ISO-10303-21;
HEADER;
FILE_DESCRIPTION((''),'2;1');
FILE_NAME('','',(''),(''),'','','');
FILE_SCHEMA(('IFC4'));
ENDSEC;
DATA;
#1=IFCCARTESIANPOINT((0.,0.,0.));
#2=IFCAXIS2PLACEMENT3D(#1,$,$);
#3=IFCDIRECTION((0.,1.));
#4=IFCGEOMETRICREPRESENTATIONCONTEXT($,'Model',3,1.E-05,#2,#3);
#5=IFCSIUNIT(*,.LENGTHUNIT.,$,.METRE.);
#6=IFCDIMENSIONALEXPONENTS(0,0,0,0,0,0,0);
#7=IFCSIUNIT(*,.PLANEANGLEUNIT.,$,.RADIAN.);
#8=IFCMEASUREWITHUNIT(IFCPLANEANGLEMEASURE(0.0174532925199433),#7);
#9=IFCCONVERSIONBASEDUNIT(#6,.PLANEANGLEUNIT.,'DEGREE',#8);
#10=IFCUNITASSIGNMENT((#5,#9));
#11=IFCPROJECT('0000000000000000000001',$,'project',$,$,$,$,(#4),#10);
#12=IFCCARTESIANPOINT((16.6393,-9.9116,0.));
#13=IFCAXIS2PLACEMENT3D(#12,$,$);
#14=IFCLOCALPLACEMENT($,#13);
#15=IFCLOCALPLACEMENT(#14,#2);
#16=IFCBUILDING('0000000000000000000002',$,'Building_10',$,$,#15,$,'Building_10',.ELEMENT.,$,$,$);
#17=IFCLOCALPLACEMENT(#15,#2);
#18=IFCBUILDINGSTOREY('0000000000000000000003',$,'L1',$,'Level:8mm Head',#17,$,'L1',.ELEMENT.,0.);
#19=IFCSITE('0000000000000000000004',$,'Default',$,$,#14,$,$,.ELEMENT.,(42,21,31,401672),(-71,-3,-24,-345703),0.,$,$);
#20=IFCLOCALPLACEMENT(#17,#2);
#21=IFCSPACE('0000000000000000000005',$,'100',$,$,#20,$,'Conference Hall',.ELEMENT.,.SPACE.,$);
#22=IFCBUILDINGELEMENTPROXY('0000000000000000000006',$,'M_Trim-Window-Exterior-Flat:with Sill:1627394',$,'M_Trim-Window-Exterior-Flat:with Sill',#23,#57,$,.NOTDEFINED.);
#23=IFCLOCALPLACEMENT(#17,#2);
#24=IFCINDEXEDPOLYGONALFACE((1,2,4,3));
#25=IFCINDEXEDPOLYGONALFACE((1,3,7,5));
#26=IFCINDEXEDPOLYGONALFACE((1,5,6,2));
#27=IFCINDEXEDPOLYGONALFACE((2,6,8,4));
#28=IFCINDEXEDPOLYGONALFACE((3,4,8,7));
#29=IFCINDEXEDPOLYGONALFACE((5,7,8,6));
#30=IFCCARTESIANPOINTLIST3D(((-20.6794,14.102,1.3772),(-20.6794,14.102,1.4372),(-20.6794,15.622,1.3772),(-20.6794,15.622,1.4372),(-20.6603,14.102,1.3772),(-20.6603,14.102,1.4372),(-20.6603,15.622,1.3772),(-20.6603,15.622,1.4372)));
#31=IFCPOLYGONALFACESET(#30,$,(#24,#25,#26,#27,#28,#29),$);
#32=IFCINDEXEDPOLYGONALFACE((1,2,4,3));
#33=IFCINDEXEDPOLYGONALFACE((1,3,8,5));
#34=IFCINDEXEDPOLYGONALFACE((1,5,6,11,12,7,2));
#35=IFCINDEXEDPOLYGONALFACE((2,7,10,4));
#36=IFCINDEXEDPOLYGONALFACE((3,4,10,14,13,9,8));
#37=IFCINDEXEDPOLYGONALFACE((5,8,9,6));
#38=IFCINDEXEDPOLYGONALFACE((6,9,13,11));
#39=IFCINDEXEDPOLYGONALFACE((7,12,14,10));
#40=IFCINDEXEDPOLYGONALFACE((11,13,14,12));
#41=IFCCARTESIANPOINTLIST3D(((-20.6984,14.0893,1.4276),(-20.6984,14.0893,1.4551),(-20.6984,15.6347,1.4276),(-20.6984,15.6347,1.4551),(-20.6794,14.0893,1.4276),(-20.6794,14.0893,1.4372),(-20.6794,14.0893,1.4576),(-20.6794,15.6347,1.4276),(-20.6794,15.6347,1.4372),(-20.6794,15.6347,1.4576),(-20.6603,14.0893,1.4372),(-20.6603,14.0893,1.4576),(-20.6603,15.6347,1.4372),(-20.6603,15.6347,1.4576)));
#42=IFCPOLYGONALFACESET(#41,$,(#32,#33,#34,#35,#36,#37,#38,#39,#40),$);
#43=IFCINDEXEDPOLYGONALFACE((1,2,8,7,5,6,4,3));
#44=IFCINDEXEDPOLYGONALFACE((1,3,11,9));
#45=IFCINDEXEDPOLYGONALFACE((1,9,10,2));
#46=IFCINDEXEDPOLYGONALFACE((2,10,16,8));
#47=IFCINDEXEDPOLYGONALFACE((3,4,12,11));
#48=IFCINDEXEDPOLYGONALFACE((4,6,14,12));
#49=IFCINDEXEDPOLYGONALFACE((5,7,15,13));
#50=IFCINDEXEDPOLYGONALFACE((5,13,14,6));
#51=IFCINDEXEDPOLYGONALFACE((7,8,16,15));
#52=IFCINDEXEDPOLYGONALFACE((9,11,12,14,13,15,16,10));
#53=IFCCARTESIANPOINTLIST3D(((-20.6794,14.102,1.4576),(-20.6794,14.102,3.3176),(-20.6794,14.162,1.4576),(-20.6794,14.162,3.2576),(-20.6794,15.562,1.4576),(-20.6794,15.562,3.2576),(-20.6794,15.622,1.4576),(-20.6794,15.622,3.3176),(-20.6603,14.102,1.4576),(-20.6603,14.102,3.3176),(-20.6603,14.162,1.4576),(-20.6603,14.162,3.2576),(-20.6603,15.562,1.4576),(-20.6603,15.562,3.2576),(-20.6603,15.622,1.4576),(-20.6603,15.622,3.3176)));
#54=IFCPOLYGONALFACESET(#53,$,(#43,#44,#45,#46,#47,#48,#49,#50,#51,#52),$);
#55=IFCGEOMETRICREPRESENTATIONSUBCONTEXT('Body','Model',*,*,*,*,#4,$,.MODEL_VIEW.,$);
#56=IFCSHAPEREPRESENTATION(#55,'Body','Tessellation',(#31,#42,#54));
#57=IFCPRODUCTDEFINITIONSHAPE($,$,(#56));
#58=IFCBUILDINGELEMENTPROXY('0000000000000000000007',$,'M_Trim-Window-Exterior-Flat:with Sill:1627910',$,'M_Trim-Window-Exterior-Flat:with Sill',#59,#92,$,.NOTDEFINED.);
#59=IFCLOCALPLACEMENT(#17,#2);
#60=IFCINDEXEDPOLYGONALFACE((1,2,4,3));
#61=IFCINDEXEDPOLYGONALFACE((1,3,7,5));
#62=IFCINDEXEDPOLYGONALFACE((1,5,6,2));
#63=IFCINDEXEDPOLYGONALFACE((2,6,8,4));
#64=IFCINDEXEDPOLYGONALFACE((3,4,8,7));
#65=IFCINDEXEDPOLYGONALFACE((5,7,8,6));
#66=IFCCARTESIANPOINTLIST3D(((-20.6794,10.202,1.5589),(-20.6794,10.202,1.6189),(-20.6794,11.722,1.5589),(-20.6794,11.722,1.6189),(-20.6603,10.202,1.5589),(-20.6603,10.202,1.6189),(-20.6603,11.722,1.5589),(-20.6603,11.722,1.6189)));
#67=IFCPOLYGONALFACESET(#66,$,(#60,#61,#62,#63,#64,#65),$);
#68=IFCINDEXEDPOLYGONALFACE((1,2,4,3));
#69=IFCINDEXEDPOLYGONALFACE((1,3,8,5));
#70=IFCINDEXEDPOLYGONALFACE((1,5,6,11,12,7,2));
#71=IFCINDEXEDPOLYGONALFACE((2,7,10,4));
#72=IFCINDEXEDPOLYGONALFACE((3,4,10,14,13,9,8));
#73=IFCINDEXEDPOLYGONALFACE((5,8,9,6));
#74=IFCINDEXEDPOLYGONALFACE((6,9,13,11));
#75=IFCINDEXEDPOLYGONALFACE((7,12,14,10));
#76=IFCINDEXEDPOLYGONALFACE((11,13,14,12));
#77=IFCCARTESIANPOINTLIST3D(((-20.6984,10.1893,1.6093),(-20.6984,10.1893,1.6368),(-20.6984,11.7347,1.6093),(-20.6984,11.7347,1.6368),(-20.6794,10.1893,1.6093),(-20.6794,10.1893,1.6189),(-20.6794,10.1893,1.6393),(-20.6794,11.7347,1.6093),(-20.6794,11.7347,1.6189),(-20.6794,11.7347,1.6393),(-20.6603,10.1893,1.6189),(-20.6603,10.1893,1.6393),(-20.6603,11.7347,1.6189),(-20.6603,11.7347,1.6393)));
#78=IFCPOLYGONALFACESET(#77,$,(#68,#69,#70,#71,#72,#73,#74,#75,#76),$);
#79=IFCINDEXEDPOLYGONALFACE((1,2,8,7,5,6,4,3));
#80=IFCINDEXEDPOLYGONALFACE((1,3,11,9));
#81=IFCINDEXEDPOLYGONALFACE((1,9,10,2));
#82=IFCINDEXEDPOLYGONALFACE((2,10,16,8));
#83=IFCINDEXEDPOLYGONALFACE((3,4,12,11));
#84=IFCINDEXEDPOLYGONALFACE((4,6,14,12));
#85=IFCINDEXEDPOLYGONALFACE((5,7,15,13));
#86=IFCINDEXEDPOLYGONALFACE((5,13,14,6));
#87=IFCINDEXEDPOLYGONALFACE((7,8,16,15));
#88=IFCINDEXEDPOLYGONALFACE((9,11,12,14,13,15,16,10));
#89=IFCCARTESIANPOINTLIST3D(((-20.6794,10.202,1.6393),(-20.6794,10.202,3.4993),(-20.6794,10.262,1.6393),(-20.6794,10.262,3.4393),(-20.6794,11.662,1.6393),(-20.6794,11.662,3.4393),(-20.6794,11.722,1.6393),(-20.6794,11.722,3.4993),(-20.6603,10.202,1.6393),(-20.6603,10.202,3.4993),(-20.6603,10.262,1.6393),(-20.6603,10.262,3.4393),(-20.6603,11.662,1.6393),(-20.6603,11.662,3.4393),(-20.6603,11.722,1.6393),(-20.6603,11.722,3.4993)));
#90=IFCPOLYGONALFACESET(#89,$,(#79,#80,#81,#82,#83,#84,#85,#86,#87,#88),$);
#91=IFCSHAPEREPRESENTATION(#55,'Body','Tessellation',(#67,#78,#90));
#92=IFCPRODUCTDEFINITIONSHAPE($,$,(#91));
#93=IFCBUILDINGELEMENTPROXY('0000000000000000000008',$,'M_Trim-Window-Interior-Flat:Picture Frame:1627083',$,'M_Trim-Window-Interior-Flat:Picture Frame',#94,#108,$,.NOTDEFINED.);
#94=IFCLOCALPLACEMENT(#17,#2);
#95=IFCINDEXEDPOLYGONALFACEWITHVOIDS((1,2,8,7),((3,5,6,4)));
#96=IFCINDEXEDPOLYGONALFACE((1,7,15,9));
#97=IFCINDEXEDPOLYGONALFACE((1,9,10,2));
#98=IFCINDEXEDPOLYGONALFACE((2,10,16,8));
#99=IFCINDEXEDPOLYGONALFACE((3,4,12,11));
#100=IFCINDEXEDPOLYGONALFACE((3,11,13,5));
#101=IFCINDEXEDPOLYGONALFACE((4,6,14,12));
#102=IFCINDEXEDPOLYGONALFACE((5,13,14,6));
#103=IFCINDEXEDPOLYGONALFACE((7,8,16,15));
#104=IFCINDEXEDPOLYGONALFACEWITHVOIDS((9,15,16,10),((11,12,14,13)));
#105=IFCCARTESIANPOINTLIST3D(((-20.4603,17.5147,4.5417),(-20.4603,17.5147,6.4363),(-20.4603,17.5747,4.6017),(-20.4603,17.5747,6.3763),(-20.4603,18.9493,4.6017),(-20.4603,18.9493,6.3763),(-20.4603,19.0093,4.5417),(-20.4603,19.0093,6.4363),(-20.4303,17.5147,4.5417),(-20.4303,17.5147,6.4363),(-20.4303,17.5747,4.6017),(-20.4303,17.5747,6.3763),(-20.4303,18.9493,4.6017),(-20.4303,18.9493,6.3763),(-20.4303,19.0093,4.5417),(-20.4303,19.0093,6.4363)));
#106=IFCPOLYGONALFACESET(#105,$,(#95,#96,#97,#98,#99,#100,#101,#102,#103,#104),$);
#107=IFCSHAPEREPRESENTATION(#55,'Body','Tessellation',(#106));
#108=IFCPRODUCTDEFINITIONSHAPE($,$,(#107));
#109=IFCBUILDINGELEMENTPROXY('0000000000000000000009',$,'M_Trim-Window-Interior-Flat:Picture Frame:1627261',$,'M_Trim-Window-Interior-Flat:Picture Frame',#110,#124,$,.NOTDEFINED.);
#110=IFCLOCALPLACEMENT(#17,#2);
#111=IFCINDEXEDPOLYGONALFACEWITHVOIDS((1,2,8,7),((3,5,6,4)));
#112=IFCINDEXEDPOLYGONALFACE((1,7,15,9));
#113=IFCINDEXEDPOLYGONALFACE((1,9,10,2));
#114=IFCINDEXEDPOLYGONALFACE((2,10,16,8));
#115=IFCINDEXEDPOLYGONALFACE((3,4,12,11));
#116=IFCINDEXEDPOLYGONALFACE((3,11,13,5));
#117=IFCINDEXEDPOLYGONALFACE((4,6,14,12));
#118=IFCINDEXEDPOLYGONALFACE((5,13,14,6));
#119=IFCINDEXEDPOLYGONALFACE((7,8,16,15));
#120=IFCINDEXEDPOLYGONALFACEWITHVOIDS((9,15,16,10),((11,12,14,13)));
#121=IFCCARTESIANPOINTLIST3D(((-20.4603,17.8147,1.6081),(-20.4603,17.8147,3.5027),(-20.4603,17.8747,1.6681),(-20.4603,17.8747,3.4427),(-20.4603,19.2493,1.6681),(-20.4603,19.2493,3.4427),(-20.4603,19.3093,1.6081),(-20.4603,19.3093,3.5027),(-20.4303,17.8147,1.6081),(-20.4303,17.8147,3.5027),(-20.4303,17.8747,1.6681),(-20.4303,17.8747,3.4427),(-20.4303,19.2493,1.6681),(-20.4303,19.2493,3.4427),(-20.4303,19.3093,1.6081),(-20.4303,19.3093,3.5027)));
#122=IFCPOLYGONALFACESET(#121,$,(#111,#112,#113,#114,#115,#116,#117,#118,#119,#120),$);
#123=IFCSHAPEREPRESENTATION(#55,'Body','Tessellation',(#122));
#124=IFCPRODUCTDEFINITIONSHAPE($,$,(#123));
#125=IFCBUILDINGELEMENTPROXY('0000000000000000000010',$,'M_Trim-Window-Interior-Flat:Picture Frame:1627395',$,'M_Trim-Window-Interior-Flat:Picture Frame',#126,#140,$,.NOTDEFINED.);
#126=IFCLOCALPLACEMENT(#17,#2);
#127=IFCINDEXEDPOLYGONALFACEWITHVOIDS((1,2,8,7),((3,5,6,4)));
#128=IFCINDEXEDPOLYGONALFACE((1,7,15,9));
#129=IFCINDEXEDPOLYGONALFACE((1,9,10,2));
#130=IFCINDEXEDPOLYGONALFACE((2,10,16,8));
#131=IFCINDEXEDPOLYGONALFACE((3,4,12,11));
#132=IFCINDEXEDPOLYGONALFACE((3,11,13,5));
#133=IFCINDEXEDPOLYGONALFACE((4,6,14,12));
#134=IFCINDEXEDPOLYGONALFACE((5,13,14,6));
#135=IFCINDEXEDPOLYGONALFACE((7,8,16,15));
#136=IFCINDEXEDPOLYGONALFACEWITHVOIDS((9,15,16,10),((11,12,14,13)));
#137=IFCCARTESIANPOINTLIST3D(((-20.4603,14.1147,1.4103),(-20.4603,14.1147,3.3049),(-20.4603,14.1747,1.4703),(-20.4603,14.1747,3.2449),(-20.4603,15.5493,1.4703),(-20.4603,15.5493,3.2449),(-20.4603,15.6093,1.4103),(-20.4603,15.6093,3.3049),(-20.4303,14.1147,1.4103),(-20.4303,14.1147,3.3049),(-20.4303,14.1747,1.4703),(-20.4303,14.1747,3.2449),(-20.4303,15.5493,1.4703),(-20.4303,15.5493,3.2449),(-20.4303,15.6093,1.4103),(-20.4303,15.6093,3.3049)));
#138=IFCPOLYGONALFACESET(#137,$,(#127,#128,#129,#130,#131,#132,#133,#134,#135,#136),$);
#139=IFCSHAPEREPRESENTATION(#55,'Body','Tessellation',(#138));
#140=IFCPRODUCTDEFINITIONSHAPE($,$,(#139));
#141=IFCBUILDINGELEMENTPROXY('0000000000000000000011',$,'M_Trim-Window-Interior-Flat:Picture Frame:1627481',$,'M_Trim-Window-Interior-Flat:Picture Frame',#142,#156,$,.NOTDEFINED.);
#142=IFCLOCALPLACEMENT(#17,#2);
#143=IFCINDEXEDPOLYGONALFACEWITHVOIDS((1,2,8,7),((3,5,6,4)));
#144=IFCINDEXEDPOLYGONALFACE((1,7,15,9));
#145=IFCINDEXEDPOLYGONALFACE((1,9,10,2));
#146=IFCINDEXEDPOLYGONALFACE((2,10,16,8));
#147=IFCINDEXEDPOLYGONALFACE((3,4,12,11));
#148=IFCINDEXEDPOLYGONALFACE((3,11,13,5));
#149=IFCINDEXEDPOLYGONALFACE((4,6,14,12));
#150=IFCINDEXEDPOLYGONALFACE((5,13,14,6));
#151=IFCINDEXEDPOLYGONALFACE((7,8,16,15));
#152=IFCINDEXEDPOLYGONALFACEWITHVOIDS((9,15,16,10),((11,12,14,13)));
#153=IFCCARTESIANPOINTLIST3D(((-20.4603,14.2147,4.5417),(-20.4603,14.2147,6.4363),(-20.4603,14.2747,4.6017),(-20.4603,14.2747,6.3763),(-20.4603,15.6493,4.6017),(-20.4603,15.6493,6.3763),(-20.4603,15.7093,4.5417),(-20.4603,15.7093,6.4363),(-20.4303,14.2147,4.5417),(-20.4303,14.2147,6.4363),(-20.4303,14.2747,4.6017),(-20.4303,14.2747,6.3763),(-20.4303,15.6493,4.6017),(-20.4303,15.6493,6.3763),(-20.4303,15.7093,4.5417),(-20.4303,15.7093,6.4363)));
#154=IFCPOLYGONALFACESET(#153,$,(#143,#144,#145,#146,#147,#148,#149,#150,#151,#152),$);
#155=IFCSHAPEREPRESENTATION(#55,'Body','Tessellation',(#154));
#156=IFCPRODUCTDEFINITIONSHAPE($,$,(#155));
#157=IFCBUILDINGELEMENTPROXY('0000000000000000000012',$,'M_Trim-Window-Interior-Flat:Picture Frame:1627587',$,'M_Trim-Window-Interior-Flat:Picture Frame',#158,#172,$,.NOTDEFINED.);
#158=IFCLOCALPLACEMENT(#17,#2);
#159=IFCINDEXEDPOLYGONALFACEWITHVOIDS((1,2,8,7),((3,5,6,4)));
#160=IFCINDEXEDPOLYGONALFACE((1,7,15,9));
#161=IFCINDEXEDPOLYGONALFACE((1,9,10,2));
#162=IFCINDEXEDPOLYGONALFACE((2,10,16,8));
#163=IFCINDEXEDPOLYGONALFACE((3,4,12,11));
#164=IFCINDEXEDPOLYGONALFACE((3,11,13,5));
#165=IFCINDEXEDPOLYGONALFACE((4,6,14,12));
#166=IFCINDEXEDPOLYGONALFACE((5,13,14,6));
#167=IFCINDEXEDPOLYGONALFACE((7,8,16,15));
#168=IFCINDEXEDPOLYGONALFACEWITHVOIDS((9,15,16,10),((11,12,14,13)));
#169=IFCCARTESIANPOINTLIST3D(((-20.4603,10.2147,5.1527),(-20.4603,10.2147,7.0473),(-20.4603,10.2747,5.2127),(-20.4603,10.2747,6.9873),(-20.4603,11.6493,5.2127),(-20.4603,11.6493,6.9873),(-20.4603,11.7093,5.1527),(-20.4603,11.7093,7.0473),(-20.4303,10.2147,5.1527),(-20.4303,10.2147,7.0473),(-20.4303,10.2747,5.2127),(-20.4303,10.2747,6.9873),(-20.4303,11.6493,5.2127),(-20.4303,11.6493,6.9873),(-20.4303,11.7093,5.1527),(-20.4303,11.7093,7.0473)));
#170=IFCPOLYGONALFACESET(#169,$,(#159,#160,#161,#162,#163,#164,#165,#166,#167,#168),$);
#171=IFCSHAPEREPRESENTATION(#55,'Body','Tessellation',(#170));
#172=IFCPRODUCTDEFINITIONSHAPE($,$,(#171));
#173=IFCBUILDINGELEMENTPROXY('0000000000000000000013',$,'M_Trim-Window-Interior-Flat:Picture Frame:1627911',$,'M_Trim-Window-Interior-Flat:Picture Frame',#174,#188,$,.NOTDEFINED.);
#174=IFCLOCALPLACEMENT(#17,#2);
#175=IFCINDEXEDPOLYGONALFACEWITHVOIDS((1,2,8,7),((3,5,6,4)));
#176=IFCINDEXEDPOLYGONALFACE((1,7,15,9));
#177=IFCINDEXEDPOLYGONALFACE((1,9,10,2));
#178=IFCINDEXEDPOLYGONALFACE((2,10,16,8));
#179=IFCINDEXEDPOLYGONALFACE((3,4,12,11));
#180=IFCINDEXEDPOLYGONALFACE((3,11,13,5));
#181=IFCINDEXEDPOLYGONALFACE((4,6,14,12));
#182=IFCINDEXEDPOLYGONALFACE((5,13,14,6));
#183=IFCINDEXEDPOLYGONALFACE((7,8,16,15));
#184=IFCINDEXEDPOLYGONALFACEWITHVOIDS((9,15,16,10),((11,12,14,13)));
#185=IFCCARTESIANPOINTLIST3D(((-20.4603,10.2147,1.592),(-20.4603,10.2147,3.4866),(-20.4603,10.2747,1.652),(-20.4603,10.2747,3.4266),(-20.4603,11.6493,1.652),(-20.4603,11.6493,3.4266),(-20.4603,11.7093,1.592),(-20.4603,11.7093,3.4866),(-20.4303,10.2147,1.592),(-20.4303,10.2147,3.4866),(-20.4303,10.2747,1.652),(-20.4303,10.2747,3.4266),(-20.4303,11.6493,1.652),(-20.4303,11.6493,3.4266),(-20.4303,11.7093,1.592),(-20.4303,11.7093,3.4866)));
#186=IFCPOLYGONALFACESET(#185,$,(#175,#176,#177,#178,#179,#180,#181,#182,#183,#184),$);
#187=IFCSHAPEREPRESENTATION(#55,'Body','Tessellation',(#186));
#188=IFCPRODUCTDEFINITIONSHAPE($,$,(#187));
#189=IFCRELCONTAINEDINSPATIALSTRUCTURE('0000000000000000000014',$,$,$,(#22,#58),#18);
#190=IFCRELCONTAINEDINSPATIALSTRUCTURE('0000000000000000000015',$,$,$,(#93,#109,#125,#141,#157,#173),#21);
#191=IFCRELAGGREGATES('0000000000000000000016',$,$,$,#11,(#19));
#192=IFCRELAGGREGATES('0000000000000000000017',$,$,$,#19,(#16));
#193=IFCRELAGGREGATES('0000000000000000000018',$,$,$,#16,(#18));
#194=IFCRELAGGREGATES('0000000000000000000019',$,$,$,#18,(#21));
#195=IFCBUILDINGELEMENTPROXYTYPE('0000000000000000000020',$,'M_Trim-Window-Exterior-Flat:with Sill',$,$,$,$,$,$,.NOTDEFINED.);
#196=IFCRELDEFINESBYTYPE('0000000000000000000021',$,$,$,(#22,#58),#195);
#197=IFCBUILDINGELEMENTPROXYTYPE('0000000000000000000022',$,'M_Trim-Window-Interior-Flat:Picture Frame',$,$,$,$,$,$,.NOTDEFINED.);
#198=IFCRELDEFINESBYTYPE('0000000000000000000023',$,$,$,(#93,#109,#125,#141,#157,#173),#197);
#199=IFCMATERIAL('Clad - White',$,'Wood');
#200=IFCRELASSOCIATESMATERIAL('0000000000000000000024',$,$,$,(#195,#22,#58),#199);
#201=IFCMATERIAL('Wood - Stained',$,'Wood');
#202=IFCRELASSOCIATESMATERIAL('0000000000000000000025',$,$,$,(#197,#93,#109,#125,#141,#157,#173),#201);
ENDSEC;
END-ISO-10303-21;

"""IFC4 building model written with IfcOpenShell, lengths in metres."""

from ifc_helpers import new_model, entity, si_unit, converted_unit, direction, frame, origin, place, context, subcontext, project, spatial, indexed_curve, outline, extrude, source, transform, mapped, material, type_object, type_shapes, element, save


model = new_model("IFC4")

# Units and contexts
model_context = context("Model", 3, precision=1e-05, world=origin(), true_north=direction((0.0, 1.0)))
body_context = subcontext(model_context, "Body", "Model", "MODEL_VIEW")
ifc_project = project(units=[si_unit("LENGTHUNIT", "METRE"), converted_unit("PLANEANGLEUNIT", "DEGREE", entity("IfcPlaneAngleMeasure", 0.0174532925199433), si_unit("PLANEANGLEUNIT", "RADIAN"), dimensions=[0, 0, 0, 0, 0, 0, 0])], contexts=[model_context])

# Site, building, storey
site_placement = place(None, frame((16.6393, -9.9116, 0.0)))
site = spatial("IfcSite", under=ifc_project, at=site_placement, Name="Default", CompositionType="ELEMENT", RefLatitude=(42, 21, 31, 401672), RefLongitude=(-71, -3, -24, -345703), RefElevation=0.0)
building_placement = place(site_placement, origin())
building = spatial("IfcBuilding", under=site, at=building_placement, Name="Building_10", LongName="Building_10", CompositionType="ELEMENT")
storey_placement = place(building_placement, origin())
storey = spatial("IfcBuildingStorey", under=building, at=storey_placement, Name="L1", ObjectType="Level:8mm Head", LongName="L1", CompositionType="ELEMENT", Elevation=0.0)

# Building element proxies
ifc_material_1 = material(Name="Clad - White", Category="Wood")
ifc_material_2 = material(Name="Wood - Stained", Category="Wood")
building_element_proxy_type_1 = type_object("IfcBuildingElementProxyType", Name="M_Trim-Window-Exterior-Flat:with Sill", PredefinedType="NOTDEFINED", material=ifc_material_1)
shared_shape_1 = source(origin(), body_context, "Body", "SweptSolid", [
    extrude(outline(indexed_curve([(-0.76, -0.03), (0.76, -0.03), (0.76, 0.03), (-0.76, 0.03), (-0.76, -0.03)], self_intersect=False)), frame((0.0, -1.8504, 0.0), z_axis=(0.0, 0.0, 1.0), x_axis=(-1.0, 0.0, 0.0)), (0.0, 0.0, 1.0), 0.0191),
    extrude(outline(indexed_curve([(-0.019, -0.0152), (0.0, -0.0152), (0.0, -0.0057), (0.019, -0.0057), (0.019, 0.0148), (0.0, 0.0148), (-0.019, 0.0123), (-0.019, -0.0152)], self_intersect=False)), frame((-0.7727, -1.8148, 0.019), z_axis=(1.0, 0.0, 0.0), x_axis=(0.0, 0.0, -1.0)), (0.0, 0.0, 1.0), 1.5454),
    extrude(outline(indexed_curve([(-0.945, -0.76), (0.915, -0.76), (0.915, -0.7), (-0.885, -0.7), (-0.885, 0.7), (0.915, 0.7), (0.915, 0.76), (-0.945, 0.76), (-0.945, -0.76)], self_intersect=False)), frame((0.0, -0.885, 0.0), z_axis=(0.0, 0.0, 1.0), x_axis=(0.0, -1.0, 0.0)), (0.0, 0.0, 1.0), 0.0191),
])
type_shapes(building_element_proxy_type_1, [shared_shape_1])
for number, where, z_axis, x_axis, name in (
    (1, (-20.6603, 14.862, 3.2576), (-1.0, 0.0, 0.0), (0.0, -1.0, 0.0), "M_Trim-Window-Exterior-Flat:with Sill:1627394"),
    (2, (-20.6603, 10.962, 3.4393), (-1.0, 0.0, 0.0), (0.0, -1.0, 0.0), "M_Trim-Window-Exterior-Flat:with Sill:1627910"),
):
    element("IfcBuildingElementProxy", number, at=place(storey_placement, frame(where, z_axis=z_axis, x_axis=x_axis)), inside=storey, type_object=building_element_proxy_type_1, material=ifc_material_1, Name=name, ObjectType="M_Trim-Window-Exterior-Flat:with Sill", PredefinedType="NOTDEFINED", context=body_context, shape_type="MappedRepresentation", body=[
        mapped(shared_shape_1, transform((0.0, 0.0, 0.0), scale=1.0)),
    ])

# Shared definitions
space_placement = place(storey_placement, origin())
space = spatial("IfcSpace", under=storey, at=space_placement, Name="100", LongName="Conference Hall", CompositionType="ELEMENT", PredefinedType="SPACE")

# Building element proxies
building_element_proxy_type_2 = type_object("IfcBuildingElementProxyType", Name="M_Trim-Window-Interior-Flat:Picture Frame", PredefinedType="NOTDEFINED", material=ifc_material_2)
shared_shape_2 = source(origin(), body_context, "Body", "SweptSolid", [
    extrude(outline(indexed_curve([(-0.7473, -0.9473), (0.7473, -0.9473), (0.7473, 0.9473), (-0.7473, 0.9473), (-0.7473, -0.9473)], self_intersect=False), holes=[indexed_curve([(-0.6873, -0.8873), (-0.6873, 0.8873), (0.6873, 0.8873), (0.6873, -0.8873), (-0.6873, -0.8873)], self_intersect=False)]), frame((0.0, -0.9, 0.0), z_axis=(0.0, 0.0, 1.0), x_axis=(-1.0, 0.0, 0.0)), (0.0, 0.0, 1.0), 0.03),
])
type_shapes(building_element_proxy_type_2, [shared_shape_2])
for number, where, z_axis, x_axis, name in (
    (3, (-20.4603, 18.262, 6.389), (1.0, 0.0, 0.0), (0.0, 1.0, 0.0), "M_Trim-Window-Interior-Flat:Picture Frame:1627083"),
    (4, (-20.4603, 18.562, 3.4554), (1.0, 0.0, 0.0), (0.0, 1.0, 0.0), "M_Trim-Window-Interior-Flat:Picture Frame:1627261"),
    (5, (-20.4603, 14.862, 3.2576), (1.0, 0.0, 0.0), (0.0, 1.0, 0.0), "M_Trim-Window-Interior-Flat:Picture Frame:1627395"),
    (6, (-20.4603, 14.962, 6.389), (1.0, 0.0, 0.0), (0.0, 1.0, 0.0), "M_Trim-Window-Interior-Flat:Picture Frame:1627481"),
    (7, (-20.4603, 10.962, 7.0), (1.0, 0.0, 0.0), (0.0, 1.0, 0.0), "M_Trim-Window-Interior-Flat:Picture Frame:1627587"),
    (8, (-20.4603, 10.962, 3.4393), (1.0, 0.0, 0.0), (0.0, 1.0, 0.0), "M_Trim-Window-Interior-Flat:Picture Frame:1627911"),
):
    element("IfcBuildingElementProxy", number, at=place(space_placement, frame(where, z_axis=z_axis, x_axis=x_axis)), inside=space, type_object=building_element_proxy_type_2, material=ifc_material_2, Name=name, ObjectType="M_Trim-Window-Interior-Flat:Picture Frame", PredefinedType="NOTDEFINED", context=body_context, shape_type="MappedRepresentation", body=[
        mapped(shared_shape_2, transform((0.0, 0.0, 0.0), scale=1.0)),
    ])

save(model, "model.ifc")
